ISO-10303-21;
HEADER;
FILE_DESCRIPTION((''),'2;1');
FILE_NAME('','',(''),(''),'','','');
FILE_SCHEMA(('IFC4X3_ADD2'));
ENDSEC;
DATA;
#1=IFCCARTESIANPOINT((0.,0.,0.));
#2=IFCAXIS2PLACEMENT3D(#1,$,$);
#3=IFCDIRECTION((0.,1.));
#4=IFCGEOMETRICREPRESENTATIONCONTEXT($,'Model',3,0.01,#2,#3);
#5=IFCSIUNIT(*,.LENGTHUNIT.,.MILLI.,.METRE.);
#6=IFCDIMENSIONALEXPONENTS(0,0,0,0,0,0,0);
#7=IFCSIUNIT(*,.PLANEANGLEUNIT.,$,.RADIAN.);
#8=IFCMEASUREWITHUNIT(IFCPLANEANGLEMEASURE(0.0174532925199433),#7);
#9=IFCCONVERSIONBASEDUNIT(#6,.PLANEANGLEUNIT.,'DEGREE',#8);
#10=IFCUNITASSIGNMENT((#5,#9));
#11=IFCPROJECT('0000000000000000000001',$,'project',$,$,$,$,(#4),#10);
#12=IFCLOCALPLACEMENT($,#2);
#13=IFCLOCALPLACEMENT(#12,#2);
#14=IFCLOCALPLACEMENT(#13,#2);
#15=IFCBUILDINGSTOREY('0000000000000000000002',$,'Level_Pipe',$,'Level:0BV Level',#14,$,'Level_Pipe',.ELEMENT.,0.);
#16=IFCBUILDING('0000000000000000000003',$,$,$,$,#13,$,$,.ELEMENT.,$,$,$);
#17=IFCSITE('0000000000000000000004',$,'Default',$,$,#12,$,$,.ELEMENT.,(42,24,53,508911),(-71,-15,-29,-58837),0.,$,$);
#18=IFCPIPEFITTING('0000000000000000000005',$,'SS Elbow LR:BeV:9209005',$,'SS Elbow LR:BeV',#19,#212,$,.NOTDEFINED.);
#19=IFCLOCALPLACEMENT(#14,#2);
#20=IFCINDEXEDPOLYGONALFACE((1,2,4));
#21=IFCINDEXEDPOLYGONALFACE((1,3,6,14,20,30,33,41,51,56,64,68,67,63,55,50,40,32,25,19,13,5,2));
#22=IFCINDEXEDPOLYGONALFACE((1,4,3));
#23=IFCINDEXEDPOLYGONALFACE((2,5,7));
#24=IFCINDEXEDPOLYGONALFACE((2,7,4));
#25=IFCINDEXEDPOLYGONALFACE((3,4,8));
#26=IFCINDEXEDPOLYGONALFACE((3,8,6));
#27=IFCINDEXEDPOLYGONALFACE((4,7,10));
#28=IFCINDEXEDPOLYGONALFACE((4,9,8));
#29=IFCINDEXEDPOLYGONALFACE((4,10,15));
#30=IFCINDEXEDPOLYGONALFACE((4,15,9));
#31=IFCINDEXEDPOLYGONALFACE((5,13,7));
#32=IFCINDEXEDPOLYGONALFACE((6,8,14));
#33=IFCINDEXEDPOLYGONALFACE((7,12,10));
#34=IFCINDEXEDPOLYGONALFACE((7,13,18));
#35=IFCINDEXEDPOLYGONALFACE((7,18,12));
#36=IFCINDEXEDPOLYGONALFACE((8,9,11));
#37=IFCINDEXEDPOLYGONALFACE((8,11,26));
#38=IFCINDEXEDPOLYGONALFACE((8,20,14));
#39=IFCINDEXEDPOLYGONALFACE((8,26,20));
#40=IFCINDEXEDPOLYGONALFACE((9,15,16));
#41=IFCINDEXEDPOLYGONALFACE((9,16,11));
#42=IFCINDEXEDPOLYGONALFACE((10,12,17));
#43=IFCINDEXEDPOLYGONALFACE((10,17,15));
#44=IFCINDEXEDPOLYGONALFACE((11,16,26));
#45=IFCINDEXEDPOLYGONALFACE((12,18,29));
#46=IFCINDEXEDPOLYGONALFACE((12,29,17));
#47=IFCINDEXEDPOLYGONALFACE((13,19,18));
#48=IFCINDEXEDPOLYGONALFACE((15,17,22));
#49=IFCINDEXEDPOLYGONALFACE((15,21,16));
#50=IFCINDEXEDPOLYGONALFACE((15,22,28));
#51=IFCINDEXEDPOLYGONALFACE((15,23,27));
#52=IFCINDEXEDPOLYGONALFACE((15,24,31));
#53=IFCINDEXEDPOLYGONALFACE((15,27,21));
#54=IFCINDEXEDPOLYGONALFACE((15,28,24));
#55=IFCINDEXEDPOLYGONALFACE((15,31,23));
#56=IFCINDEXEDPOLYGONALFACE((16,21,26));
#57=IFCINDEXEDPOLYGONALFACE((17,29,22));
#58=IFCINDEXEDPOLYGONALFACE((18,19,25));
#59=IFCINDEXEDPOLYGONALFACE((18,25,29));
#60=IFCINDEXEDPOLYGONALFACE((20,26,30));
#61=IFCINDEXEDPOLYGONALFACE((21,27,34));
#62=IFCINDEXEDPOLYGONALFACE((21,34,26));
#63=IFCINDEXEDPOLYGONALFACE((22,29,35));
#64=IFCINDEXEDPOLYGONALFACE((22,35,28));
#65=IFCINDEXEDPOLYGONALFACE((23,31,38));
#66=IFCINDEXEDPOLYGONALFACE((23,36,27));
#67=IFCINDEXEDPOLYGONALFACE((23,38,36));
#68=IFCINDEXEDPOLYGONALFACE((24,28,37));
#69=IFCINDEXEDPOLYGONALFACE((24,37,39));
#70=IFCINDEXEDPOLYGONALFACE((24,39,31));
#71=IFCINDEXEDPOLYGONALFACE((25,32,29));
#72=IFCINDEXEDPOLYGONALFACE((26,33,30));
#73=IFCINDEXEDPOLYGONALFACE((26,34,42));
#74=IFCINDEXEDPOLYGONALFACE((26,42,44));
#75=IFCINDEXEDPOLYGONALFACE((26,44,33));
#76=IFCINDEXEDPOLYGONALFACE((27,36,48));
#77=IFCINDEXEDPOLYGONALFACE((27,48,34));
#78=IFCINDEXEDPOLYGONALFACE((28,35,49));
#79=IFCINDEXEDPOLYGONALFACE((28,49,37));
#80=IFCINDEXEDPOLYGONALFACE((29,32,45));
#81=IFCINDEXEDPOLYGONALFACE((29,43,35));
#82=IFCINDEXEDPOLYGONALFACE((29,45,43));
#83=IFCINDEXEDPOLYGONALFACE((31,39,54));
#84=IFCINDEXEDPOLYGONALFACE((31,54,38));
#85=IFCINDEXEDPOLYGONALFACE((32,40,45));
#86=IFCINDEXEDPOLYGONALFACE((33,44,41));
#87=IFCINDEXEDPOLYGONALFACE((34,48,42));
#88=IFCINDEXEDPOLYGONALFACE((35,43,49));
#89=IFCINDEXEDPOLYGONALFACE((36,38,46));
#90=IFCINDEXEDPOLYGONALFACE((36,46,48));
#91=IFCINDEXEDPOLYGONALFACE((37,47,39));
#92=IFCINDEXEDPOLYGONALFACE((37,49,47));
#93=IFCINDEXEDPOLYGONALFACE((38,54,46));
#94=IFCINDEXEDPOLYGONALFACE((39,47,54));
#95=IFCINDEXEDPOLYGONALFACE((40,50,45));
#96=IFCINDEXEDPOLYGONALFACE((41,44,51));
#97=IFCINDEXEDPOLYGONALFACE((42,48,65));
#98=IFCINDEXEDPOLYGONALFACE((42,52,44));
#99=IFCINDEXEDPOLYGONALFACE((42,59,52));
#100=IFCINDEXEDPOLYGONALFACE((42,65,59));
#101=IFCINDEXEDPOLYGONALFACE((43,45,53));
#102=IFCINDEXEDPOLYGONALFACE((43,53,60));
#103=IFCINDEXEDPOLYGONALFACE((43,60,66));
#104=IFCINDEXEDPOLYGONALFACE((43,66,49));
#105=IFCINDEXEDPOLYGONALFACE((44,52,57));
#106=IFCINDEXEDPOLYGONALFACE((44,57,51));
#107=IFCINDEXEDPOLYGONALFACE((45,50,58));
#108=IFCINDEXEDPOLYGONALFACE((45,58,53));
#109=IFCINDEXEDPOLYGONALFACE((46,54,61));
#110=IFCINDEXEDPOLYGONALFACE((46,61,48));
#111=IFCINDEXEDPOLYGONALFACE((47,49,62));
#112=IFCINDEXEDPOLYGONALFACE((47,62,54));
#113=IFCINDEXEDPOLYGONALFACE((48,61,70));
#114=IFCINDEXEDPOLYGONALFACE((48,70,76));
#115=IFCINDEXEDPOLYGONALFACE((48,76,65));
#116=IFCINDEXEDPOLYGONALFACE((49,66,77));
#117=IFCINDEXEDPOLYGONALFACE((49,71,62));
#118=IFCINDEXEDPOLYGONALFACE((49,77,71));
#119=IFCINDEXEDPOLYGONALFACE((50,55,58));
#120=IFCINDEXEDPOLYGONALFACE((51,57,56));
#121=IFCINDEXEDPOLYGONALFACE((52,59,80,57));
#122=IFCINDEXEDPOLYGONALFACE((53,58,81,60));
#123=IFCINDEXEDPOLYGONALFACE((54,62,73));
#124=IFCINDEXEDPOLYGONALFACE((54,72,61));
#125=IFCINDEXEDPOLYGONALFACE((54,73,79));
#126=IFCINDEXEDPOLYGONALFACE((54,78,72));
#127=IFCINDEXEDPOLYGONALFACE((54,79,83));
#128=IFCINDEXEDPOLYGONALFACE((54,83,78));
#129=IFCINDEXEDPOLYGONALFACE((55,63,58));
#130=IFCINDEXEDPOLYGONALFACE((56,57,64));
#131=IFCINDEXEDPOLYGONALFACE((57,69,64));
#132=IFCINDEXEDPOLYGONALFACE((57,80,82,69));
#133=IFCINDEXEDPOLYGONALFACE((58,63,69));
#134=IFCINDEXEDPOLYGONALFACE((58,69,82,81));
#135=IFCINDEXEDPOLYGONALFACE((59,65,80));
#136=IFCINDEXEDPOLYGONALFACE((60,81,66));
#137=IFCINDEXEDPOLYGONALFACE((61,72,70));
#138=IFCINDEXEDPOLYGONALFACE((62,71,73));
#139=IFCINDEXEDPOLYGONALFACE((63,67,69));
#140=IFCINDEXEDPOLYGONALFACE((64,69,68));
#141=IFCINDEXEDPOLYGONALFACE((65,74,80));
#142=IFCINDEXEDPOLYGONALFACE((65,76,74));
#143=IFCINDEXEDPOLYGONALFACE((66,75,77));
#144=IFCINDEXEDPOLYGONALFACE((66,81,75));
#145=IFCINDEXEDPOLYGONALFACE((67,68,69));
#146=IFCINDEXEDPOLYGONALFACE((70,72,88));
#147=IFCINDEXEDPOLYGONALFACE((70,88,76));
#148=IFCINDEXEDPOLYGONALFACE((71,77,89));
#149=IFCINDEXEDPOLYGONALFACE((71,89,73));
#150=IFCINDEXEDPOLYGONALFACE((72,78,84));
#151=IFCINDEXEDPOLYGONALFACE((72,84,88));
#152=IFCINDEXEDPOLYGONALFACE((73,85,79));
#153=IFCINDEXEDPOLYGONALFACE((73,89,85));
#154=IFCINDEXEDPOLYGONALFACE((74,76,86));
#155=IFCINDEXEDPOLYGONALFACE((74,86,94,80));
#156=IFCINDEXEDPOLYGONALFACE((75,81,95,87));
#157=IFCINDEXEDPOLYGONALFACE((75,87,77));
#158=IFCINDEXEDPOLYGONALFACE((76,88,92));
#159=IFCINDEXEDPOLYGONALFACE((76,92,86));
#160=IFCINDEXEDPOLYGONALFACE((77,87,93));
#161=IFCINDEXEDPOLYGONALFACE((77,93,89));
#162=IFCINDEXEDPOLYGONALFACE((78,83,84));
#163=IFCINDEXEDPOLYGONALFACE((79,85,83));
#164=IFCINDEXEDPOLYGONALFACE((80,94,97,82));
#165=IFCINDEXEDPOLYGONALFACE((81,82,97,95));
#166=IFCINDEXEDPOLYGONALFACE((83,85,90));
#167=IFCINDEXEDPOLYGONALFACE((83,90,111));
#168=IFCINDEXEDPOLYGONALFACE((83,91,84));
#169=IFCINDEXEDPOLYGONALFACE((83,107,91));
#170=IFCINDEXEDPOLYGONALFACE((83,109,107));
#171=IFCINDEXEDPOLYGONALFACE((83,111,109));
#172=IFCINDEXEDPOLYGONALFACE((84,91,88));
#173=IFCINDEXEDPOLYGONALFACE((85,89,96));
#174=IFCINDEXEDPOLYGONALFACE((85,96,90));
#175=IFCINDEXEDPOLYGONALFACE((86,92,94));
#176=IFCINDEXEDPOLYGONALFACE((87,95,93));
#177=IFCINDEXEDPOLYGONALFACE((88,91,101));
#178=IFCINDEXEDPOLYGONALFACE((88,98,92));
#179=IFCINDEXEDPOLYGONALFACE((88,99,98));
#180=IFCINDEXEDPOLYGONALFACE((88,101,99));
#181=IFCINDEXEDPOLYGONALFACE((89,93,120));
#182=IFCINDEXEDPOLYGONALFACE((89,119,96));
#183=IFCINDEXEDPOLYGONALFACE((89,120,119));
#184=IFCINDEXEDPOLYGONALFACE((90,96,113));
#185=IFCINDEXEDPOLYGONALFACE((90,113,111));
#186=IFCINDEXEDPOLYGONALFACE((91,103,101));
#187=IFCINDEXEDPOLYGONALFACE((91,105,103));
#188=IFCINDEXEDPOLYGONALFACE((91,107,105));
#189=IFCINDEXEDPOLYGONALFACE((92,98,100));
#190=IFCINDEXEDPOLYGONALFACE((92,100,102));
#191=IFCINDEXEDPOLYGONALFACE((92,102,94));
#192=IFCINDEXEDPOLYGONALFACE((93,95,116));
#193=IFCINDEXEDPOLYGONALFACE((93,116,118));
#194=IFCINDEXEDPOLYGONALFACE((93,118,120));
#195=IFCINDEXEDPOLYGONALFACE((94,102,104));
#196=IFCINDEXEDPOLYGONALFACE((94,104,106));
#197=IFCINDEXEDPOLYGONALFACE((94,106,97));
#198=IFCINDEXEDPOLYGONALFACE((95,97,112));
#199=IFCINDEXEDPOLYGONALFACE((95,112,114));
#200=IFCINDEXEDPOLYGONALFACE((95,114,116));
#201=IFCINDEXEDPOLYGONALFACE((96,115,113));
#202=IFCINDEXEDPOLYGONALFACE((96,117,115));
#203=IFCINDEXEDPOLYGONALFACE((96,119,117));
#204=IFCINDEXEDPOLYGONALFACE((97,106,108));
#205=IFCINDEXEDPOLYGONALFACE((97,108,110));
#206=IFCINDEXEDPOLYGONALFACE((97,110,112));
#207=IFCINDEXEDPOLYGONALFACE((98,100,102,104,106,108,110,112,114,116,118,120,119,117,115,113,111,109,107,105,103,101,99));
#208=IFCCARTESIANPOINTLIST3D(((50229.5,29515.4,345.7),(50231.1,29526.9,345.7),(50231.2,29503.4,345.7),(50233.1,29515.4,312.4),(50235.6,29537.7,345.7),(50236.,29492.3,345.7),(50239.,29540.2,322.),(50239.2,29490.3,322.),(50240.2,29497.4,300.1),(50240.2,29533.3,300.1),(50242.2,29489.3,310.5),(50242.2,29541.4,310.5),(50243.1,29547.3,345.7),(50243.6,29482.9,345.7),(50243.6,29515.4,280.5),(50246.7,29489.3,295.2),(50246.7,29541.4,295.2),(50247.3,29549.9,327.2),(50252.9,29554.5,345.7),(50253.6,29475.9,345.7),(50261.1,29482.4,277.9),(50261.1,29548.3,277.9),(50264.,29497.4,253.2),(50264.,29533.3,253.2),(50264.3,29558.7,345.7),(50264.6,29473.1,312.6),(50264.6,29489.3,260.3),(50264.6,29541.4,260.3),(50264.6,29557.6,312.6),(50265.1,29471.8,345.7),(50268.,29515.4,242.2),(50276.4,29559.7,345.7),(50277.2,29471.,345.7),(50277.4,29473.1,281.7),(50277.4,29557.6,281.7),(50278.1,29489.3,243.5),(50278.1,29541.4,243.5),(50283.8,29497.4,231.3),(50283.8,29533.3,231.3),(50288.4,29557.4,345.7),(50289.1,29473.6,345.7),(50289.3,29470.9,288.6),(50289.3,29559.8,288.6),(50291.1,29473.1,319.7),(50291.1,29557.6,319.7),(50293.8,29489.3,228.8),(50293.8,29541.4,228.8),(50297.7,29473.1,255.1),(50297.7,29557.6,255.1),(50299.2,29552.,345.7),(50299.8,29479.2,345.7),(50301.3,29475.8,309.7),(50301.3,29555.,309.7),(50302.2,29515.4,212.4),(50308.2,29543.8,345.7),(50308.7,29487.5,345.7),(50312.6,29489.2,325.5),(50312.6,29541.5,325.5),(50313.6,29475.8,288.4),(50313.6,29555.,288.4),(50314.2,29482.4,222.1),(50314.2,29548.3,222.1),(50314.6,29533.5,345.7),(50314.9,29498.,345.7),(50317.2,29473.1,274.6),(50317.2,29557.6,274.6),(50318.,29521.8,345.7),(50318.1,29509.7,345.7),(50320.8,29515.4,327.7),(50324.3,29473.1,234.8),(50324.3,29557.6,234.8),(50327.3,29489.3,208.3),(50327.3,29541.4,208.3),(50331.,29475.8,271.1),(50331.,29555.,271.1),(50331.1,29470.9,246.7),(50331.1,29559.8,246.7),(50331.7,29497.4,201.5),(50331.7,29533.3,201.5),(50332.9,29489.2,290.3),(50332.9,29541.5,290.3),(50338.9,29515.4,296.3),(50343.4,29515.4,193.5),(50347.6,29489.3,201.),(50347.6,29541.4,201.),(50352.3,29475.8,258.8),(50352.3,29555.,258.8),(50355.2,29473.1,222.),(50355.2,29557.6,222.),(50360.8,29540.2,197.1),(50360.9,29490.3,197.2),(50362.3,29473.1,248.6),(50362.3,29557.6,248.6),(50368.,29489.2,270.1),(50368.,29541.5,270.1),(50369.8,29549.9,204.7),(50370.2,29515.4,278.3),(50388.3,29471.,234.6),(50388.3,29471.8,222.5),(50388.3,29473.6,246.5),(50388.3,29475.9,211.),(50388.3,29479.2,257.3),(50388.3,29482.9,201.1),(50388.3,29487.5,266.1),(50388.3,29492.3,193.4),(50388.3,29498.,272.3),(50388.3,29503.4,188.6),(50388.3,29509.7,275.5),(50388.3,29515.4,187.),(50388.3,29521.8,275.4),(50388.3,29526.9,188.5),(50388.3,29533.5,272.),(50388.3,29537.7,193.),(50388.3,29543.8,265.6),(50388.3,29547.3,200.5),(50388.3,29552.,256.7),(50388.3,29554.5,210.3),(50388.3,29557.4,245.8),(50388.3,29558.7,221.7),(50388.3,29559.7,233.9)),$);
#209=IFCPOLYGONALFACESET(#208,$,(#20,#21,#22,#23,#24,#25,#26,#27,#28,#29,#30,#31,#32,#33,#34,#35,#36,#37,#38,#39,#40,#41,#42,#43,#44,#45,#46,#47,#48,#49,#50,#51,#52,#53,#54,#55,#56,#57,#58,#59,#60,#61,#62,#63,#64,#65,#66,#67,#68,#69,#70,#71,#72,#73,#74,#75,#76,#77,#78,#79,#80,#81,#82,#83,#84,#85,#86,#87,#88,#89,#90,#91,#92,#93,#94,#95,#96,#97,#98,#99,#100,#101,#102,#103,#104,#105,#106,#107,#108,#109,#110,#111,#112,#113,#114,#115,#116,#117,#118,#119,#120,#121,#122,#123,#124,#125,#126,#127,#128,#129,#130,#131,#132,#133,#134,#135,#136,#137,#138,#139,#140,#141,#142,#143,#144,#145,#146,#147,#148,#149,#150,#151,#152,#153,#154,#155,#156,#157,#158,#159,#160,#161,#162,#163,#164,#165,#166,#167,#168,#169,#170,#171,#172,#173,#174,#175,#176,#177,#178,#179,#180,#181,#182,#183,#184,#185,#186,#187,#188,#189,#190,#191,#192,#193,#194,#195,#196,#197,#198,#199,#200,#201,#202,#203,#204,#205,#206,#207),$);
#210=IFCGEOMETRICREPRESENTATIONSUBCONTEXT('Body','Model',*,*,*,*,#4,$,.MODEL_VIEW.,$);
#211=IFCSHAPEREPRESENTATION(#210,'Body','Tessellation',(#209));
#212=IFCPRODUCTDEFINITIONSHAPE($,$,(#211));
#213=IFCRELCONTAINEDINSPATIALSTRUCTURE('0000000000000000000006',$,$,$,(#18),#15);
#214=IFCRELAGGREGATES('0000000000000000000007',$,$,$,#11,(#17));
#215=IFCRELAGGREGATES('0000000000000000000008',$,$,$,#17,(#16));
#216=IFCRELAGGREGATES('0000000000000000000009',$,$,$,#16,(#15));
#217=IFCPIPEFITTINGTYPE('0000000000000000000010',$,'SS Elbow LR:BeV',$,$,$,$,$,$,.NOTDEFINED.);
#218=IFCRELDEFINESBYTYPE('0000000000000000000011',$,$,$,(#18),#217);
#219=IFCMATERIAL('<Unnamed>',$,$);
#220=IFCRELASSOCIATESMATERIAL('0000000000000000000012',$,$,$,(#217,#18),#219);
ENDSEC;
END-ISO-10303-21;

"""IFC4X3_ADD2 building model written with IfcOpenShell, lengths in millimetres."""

from ifc_helpers import new_model, entity, si_unit, converted_unit, direction, frame, origin, place, context, subcontext, project, spatial, source, transform, mapped, material, type_object, type_shapes, element, save


model = new_model("IFC4X3_ADD2")

# Units and contexts
model_context = context("Model", 3, precision=0.01, world=origin(), true_north=direction((0.0, 1.0)))
body_context = subcontext(model_context, "Body", "Model", "MODEL_VIEW")
ifc_project = project(units=[si_unit("LENGTHUNIT", "METRE", prefix="MILLI"), converted_unit("PLANEANGLEUNIT", "DEGREE", entity("IfcPlaneAngleMeasure", 0.0174532925199433), si_unit("PLANEANGLEUNIT", "RADIAN"), dimensions=[0, 0, 0, 0, 0, 0, 0])], contexts=[model_context])

# Site, building, storey
site_placement = place(None, origin())
site = spatial("IfcSite", under=ifc_project, at=site_placement, Name="Default", CompositionType="ELEMENT", RefLatitude=(42, 24, 53, 508911), RefLongitude=(-71, -15, -29, -58837), RefElevation=0.0)
building_placement = place(site_placement, origin())
building = spatial("IfcBuilding", under=site, at=building_placement, CompositionType="ELEMENT")
storey_placement = place(building_placement, origin())
storey = spatial("IfcBuildingStorey", under=building, at=storey_placement, Name="Level_Pipe", ObjectType="Level:0BV Level", LongName="Level_Pipe", CompositionType="ELEMENT", Elevation=0.0)

# Pipe fitting
ifc_material_1 = material(Name="<Unnamed>")
pipe_fitting_type_1 = type_object("IfcPipeFittingType", Name="SS Elbow LR:BeV", PredefinedType="NOTDEFINED", material=ifc_material_1)
ifc_direction = entity("IfcDirection", [1.0, 0.0])
trimmed_curve_1 = entity("IfcTrimmedCurve", entity("IfcCircle", entity("IfcAxis2Placement2D", entity("IfcCartesianPoint", [-69.8, 0.0]), ifc_direction), 69.8), [entity("IfcParameterValue", 0.0)], [entity("IfcParameterValue", 90.0)], True, "PARAMETER")
shared_shape_1 = source(origin(), body_context, "Body", "AdvancedSweptSolid", [
    entity("IfcSurfaceCurveSweptAreaSolid", entity("IfcCircleProfileDef", "AREA", None, entity("IfcAxis2Placement2D", entity("IfcCartesianPoint", [44.5, 0.0]), ifc_direction), 44.5), entity("IfcAxis2Placement3D", entity("IfcCartesianPoint", [-114.3, -44.5, 0.0]), entity("IfcDirection", [0.0, 0.0, -1.0]), entity("IfcDirection", [0.0, 1.0, 0.0])), trimmed_curve_1, entity("IfcParameterValue", 0.0), entity("IfcParameterValue", 90.0), entity("IfcSurfaceOfLinearExtrusion", entity("IfcArbitraryOpenProfileDef", "CURVE", None, trimmed_curve_1), entity("IfcAxis2Placement3D", entity("IfcCartesianPoint", [0.0, 0.0, -304.8])), entity("IfcDirection", [0.0, 0.0, 1.0]), 1.0)),
])
type_shapes(pipe_fitting_type_1, [shared_shape_1])
pipe_fitting_1_placement = place(storey_placement, frame((50274.0, 29515.4, 231.4), z_axis=(0.0, -1.0, 0.0), x_axis=(-1.0, 0.0, 0.0)))
element("IfcPipeFitting", 1, at=pipe_fitting_1_placement, inside=storey, type_object=pipe_fitting_type_1, material=ifc_material_1, Name="SS Elbow LR:BeV:9209005", ObjectType="SS Elbow LR:BeV", PredefinedType="NOTDEFINED", context=body_context, shape_type="MappedRepresentation", body=[
    mapped(shared_shape_1, transform((0.0, 0.0, 0.0), scale=1.0)),
])

save(model, "model.ifc")
